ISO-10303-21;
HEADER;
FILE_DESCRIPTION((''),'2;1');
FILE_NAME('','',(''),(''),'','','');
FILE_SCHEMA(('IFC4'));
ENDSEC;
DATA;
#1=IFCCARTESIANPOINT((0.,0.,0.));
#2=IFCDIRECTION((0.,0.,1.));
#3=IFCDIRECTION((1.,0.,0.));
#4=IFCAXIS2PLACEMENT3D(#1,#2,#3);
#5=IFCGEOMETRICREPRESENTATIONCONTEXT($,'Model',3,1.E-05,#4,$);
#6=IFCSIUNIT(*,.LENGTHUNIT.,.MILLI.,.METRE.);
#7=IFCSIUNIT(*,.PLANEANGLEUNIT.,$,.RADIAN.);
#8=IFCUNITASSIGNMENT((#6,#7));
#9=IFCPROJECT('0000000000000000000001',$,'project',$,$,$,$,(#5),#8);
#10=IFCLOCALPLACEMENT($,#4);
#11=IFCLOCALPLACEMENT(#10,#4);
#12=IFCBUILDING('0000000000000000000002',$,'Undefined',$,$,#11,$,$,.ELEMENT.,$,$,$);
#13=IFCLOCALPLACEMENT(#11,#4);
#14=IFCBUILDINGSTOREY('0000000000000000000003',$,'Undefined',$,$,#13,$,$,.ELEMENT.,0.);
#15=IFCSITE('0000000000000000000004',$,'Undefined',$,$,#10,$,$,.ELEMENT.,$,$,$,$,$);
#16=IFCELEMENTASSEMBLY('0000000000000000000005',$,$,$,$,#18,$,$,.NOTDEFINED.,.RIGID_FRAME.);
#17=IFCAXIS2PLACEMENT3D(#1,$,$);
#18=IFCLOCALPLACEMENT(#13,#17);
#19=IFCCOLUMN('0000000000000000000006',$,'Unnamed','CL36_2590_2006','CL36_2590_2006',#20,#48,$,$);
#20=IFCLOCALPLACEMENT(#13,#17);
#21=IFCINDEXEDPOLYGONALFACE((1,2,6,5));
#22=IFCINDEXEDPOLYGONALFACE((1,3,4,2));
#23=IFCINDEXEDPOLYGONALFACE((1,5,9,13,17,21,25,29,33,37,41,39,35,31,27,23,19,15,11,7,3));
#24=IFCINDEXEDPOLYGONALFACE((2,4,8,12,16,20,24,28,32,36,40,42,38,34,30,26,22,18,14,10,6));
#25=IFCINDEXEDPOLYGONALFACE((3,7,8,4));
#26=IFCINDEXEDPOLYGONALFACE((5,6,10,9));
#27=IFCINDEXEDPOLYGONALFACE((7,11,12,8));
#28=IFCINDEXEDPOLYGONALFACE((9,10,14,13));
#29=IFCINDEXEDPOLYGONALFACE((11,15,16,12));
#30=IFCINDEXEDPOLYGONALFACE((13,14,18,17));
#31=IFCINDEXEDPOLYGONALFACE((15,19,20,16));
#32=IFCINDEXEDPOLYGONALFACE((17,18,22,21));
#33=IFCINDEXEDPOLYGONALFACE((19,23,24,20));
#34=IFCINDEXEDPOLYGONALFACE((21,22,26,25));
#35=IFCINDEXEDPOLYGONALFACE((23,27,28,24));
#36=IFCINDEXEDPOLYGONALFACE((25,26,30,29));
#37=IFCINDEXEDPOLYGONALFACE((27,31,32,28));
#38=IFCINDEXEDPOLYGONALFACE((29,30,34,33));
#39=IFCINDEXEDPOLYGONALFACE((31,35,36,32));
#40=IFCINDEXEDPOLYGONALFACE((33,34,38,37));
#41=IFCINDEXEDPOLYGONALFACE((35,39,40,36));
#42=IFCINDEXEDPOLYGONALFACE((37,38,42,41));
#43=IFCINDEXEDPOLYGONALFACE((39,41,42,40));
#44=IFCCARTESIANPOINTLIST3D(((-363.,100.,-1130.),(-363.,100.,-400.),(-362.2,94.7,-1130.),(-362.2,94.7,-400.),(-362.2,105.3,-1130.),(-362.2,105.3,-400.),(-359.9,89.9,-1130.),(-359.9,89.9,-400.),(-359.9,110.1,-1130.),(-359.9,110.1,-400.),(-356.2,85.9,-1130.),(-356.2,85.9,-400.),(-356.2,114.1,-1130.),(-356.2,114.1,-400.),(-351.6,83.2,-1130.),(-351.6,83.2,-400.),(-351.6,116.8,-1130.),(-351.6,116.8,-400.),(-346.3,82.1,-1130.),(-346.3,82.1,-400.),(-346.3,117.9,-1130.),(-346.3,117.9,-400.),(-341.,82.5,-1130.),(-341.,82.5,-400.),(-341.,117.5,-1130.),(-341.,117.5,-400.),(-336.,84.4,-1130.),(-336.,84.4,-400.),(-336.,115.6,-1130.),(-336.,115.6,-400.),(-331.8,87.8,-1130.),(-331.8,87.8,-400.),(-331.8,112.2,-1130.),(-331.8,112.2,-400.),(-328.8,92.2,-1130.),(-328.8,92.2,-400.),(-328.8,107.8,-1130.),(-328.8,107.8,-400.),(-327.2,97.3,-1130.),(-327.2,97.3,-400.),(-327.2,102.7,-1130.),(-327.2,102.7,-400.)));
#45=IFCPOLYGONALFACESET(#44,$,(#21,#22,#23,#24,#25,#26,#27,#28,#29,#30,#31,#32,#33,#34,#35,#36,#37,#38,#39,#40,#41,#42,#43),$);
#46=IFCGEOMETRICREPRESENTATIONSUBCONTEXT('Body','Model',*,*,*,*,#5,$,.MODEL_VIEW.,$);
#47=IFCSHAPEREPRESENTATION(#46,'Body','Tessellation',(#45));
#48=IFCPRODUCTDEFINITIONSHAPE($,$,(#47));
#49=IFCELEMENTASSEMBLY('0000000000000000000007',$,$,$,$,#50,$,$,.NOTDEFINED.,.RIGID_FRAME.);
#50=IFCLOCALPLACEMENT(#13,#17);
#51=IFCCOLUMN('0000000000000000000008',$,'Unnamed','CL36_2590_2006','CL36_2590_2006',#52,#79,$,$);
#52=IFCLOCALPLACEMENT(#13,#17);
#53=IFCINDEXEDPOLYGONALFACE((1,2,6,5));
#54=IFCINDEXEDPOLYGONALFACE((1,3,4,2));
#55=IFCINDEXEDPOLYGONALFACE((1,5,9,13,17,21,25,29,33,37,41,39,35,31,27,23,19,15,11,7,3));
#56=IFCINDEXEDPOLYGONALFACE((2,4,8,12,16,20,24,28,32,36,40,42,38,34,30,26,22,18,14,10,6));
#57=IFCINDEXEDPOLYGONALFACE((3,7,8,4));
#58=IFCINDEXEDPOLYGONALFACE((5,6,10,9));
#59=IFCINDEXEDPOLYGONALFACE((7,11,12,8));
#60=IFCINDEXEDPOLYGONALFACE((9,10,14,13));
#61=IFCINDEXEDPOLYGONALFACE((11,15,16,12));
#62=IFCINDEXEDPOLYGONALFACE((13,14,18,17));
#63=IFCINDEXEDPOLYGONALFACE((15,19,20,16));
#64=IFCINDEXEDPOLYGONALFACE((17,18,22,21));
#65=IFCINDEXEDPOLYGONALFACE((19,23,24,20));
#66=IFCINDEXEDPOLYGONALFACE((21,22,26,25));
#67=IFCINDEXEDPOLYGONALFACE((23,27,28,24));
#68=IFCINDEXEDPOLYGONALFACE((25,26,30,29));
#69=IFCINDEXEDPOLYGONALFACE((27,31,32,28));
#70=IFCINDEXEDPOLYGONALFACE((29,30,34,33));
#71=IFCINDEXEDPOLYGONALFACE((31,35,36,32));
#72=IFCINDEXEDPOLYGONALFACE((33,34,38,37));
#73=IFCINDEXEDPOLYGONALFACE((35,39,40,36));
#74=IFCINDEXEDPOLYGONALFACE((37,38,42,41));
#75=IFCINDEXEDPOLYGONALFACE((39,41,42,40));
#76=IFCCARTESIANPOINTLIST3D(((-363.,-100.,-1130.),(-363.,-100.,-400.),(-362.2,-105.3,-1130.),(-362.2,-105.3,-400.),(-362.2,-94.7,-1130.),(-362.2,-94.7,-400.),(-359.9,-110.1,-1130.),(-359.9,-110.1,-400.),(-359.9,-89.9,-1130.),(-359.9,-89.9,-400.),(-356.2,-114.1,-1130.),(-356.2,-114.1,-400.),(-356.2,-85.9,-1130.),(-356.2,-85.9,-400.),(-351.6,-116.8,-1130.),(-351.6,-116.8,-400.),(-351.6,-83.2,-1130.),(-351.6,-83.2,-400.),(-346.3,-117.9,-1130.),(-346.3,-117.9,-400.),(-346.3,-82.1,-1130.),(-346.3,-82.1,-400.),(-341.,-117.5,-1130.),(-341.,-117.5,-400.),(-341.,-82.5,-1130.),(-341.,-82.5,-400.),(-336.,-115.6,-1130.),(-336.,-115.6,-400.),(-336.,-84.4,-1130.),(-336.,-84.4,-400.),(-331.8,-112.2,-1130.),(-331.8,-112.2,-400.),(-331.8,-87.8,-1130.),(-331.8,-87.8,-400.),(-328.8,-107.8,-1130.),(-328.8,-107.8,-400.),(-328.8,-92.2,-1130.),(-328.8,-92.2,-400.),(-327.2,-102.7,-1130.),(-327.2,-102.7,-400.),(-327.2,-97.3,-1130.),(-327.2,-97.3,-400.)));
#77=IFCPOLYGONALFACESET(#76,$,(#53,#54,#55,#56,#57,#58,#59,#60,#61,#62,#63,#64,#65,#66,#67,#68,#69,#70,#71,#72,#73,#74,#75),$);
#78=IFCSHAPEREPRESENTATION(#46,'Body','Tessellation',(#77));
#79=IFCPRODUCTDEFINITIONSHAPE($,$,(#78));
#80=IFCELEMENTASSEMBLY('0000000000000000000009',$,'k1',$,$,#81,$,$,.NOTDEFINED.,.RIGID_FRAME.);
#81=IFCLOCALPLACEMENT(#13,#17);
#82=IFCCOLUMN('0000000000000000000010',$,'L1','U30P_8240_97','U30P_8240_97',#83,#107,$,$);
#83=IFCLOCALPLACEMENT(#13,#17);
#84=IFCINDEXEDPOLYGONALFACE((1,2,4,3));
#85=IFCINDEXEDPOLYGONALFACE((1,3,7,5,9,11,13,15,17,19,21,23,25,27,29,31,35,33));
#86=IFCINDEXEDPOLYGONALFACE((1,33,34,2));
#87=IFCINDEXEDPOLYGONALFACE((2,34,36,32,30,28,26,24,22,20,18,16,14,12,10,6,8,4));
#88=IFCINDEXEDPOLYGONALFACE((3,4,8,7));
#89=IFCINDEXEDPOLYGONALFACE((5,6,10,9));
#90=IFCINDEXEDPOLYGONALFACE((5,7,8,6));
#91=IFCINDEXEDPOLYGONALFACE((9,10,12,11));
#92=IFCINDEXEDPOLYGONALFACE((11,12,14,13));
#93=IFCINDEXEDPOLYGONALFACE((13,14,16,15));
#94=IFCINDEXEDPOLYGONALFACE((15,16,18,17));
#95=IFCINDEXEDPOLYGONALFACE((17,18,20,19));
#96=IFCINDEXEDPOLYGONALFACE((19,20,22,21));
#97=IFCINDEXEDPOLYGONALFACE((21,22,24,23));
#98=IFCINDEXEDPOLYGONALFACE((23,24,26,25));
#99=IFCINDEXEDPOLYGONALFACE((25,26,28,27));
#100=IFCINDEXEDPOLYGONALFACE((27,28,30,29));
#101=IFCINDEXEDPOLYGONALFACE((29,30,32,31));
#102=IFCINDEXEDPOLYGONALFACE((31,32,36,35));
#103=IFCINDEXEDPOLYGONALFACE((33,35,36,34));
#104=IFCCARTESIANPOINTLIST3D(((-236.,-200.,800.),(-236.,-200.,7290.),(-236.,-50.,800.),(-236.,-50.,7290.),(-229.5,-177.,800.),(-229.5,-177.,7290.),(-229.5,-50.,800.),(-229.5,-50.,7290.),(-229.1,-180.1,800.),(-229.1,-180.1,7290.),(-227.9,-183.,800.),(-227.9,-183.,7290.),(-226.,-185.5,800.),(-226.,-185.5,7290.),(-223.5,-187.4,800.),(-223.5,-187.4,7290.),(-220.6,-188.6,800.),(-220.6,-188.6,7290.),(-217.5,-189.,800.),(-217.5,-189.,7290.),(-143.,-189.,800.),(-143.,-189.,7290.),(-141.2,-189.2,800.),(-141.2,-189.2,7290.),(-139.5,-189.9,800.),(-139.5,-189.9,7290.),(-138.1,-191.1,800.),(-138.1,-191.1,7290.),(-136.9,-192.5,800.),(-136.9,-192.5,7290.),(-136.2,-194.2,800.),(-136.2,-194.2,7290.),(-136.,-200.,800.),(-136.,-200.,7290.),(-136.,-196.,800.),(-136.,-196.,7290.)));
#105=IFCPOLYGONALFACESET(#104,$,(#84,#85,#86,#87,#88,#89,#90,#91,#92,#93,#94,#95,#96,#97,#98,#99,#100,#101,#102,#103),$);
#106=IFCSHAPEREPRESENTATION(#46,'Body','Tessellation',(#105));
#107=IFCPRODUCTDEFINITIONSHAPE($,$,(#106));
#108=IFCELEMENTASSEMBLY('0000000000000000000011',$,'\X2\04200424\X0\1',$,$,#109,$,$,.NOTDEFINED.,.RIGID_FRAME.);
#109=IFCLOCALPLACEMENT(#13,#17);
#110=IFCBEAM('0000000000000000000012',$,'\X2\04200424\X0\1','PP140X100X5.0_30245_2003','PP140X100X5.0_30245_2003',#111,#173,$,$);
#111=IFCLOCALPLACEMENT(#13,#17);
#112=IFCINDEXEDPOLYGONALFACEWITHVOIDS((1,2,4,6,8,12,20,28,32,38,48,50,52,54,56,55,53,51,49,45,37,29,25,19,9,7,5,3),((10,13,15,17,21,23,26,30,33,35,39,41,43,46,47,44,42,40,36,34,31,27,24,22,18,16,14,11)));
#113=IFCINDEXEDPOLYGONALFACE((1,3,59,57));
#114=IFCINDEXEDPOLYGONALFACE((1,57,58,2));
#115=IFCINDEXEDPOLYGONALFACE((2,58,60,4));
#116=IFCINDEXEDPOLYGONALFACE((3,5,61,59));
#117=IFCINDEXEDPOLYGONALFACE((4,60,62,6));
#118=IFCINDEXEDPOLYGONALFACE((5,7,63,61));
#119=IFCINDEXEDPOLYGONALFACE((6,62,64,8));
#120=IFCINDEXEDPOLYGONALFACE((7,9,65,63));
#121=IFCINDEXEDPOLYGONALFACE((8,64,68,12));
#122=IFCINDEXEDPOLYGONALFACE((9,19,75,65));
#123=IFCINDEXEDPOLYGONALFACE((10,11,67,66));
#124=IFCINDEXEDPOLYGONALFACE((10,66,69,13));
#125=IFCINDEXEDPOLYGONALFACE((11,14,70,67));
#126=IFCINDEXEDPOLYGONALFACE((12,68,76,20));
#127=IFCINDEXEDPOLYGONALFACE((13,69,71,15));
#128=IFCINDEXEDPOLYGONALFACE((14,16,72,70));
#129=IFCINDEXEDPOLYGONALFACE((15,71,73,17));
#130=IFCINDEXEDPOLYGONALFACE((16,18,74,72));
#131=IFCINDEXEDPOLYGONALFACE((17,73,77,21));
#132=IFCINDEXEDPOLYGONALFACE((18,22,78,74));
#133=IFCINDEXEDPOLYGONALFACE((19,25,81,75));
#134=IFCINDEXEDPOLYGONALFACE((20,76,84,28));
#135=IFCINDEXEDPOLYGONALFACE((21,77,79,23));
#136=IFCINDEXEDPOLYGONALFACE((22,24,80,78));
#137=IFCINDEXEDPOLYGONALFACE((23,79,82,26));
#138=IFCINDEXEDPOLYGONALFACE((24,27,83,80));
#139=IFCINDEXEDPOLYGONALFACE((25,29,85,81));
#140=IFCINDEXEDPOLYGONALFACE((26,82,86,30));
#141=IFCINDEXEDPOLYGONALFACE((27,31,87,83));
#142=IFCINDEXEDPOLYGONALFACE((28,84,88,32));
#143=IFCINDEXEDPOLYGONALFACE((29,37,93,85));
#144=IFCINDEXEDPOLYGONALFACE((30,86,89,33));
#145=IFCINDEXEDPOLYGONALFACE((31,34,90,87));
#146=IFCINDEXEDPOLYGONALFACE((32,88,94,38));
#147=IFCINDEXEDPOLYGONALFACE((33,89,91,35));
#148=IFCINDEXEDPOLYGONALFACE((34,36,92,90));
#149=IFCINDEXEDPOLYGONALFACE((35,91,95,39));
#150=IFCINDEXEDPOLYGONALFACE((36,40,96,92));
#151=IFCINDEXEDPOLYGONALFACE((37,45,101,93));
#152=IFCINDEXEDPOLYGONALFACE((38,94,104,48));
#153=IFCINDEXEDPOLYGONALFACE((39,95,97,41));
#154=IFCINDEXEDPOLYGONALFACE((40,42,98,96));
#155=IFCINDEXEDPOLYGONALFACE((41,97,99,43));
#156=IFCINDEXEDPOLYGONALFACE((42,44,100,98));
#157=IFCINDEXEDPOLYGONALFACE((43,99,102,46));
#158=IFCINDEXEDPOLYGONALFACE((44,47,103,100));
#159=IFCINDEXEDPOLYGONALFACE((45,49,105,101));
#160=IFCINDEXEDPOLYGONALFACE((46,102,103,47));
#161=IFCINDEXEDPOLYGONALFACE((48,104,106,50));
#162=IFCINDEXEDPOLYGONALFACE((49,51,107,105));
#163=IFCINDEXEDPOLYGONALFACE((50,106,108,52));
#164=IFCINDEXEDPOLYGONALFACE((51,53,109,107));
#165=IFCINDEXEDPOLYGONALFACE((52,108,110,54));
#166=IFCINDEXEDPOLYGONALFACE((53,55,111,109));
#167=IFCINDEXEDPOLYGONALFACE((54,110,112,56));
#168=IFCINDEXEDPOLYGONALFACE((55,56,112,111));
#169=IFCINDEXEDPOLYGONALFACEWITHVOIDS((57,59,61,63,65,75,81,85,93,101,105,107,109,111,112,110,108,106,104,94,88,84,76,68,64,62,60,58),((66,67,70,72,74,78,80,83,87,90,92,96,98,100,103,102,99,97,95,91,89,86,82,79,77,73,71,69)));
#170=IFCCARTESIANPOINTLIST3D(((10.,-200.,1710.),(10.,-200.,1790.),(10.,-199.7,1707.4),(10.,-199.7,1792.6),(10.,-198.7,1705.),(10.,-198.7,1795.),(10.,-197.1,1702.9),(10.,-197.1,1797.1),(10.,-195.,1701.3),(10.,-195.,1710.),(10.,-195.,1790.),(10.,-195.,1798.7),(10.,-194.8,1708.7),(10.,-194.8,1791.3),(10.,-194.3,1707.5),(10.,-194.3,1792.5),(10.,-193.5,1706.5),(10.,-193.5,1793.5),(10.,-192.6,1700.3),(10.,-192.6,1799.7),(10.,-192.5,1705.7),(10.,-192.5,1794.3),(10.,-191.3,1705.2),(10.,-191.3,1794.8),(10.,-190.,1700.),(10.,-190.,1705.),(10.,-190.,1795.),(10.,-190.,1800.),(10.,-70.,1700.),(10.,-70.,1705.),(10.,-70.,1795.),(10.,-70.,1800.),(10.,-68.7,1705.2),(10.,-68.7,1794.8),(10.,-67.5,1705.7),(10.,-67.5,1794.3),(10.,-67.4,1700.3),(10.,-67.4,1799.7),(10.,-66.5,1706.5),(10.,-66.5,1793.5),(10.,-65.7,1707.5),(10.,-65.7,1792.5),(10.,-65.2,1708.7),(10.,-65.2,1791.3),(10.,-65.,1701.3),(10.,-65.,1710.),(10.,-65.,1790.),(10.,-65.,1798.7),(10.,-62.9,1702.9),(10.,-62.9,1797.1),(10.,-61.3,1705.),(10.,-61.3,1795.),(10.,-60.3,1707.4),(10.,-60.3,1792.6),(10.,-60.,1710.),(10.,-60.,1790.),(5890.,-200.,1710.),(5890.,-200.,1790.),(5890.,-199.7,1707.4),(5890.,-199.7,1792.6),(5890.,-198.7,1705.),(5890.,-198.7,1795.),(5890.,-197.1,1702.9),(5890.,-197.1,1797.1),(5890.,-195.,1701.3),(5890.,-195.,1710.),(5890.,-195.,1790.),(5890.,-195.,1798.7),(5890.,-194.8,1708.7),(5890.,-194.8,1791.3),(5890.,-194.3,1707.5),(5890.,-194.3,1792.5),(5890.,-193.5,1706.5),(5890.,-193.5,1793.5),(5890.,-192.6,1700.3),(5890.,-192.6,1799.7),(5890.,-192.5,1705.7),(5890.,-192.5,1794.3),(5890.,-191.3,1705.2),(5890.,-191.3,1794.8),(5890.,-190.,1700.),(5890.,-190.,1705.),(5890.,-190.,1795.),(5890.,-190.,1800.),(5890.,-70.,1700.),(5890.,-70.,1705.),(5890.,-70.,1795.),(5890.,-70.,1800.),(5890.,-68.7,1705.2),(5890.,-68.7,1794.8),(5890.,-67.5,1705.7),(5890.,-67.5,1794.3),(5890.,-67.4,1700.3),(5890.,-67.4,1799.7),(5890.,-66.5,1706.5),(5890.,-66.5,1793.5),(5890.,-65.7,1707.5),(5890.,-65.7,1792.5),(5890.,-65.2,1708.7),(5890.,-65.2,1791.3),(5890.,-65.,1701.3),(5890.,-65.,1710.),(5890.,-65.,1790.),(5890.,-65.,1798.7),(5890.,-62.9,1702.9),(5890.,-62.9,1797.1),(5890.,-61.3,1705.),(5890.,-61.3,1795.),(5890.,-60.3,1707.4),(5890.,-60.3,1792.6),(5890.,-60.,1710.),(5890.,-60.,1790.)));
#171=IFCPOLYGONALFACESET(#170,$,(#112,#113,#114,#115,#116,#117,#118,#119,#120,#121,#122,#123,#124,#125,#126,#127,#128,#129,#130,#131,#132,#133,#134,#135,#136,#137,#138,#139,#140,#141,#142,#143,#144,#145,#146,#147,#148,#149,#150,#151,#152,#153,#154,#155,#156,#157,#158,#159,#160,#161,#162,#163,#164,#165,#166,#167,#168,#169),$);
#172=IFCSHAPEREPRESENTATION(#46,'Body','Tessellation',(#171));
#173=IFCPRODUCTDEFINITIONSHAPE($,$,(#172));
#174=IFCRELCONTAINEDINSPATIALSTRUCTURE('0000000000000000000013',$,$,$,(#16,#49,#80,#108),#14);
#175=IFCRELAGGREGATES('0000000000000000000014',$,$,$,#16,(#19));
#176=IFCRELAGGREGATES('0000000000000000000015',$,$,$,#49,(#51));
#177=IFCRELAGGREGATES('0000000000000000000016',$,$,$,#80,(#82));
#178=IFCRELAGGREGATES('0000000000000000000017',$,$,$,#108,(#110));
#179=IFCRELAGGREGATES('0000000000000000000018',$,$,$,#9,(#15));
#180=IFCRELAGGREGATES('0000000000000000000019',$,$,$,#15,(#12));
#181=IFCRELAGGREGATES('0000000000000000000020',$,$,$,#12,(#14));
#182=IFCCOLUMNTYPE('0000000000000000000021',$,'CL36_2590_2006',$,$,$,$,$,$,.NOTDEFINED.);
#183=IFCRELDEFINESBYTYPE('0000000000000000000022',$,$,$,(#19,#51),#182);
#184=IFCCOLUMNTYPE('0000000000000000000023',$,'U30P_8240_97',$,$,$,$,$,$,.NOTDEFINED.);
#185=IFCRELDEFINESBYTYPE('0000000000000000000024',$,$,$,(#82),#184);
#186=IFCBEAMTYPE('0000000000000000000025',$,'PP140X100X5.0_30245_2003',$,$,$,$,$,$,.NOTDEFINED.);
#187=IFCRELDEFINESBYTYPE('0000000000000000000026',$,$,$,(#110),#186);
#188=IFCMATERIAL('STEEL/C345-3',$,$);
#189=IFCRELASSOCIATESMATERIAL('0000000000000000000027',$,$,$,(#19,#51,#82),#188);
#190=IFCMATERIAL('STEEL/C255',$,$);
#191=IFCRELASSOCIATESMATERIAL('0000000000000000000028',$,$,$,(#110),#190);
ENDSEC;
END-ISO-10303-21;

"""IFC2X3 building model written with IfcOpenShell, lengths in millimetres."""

from ifc_helpers import new_model, si_unit, frame, origin_with_axes, origin_2d_with_axis, place, context, subcontext, project, spatial, hollow_rectangle, circle, u_section, extrude, clip, halfspace, material, type_object, element, aggregate, save


model = new_model("IFC2X3")

# Units and contexts
model_context = context("Model", 3, precision=1e-05, world=origin_with_axes())
body_context = subcontext(model_context, "Body", "Model", "MODEL_VIEW")
ifc_project = project(units=[si_unit("LENGTHUNIT", "METRE", prefix="MILLI"), si_unit("PLANEANGLEUNIT", "RADIAN")], contexts=[model_context])

# Site, building, storey
site_placement = place(None, origin_with_axes())
site = spatial("IfcSite", under=ifc_project, at=site_placement, Name="Undefined", CompositionType="ELEMENT")
building_placement = place(site_placement, origin_with_axes())
building = spatial("IfcBuilding", under=site, at=building_placement, Name="Undefined", CompositionType="ELEMENT")
storey_placement = place(building_placement, origin_with_axes())
storey = spatial("IfcBuildingStorey", under=building, at=storey_placement, Name="Undefined", CompositionType="ELEMENT", Elevation=0.0)

# Element assemblies, columns
ifc_material_1 = material(Name="STEEL/C255")
ifc_material_2 = material(Name="STEEL/C345-3")
column_type_1 = type_object("IfcColumnType", Name="CL36_2590_2006", PredefinedType="NOTDEFINED")
assembly_1_placement = place(storey_placement, origin_with_axes())
assembly_1 = element("IfcElementAssembly", 1, at=assembly_1_placement, inside=storey, AssemblyPlace="NOTDEFINED", PredefinedType="RIGID_FRAME")
column_1_placement = place(assembly_1_placement, frame((-345.0, 100.0, -1130.0), z_axis=(0.0, 0.0, 1.0), x_axis=(0.0, 1.0, 0.0)))
column_1 = element("IfcColumn", 2, at=column_1_placement, type_object=column_type_1, material=ifc_material_2, Name="Unnamed", Description="CL36_2590_2006", ObjectType="CL36_2590_2006", context=body_context, shape_type="SweptSolid", body=[
    extrude(circle(Radius=18.0, at=origin_2d_with_axis()), frame((0.0, 0.0, 730.0), z_axis=(0.0, 0.0, -1.0), x_axis=(0.0, 1.0, 0.0)), (0.0, 0.0, 1.0), 730.0),
])
aggregate(assembly_1, [column_1])
assembly_2_placement = place(storey_placement, origin_with_axes())
assembly_2 = element("IfcElementAssembly", 3, at=assembly_2_placement, inside=storey, AssemblyPlace="NOTDEFINED", PredefinedType="RIGID_FRAME")
column_2_placement = place(assembly_2_placement, frame((-345.0, -100.0, -1130.0), z_axis=(0.0, 0.0, 1.0), x_axis=(0.0, 1.0, 0.0)))
column_2 = element("IfcColumn", 4, at=column_2_placement, type_object=column_type_1, material=ifc_material_2, Name="Unnamed", Description="CL36_2590_2006", ObjectType="CL36_2590_2006", context=body_context, shape_type="SweptSolid", body=[
    extrude(circle(Radius=18.0, at=origin_2d_with_axis()), frame((0.0, 0.0, 730.0), z_axis=(0.0, 0.0, -1.0), x_axis=(0.0, 1.0, 0.0)), (0.0, 0.0, 1.0), 730.0),
])
aggregate(assembly_2, [column_2])
assembly_3_placement = place(storey_placement, origin_with_axes())
assembly_3 = element("IfcElementAssembly", 5, at=assembly_3_placement, inside=storey, Name="k1", AssemblyPlace="NOTDEFINED", PredefinedType="RIGID_FRAME")
column_type_2 = type_object("IfcColumnType", Name="U30P_8240_97", PredefinedType="NOTDEFINED")
column_3_placement = place(assembly_3_placement, frame((-186.0, -50.0, 800.0), z_axis=(0.0, 0.0, 1.0), x_axis=(0.0, -1.0, 0.0)))
column_3 = element("IfcColumn", 6, at=column_3_placement, type_object=column_type_2, material=ifc_material_2, Name="L1", Description="U30P_8240_97", ObjectType="U30P_8240_97", context=body_context, shape_type="Clipping", body=[
    clip(extrude(u_section(Depth=300.0, FlangeWidth=100.0, WebThickness=6.5, FlangeThickness=11.0, FilletRadius=12.0, EdgeRadius=7.0, at=origin_2d_with_axis()), frame((0.0, 0.0, 6490.0), z_axis=(0.0, 0.0, -1.0), x_axis=(0.0, 1.0, 0.0)), (0.0, 0.0, 1.0), 6490.0), halfspace(frame((0.0, -50.0, 0.0), z_axis=(-1.0, 0.0, 0.0), x_axis=(0.0, 1.0, 0.0)), False)),
])
aggregate(assembly_3, [column_3])

# Element assembly, beam
assembly_4_placement = place(storey_placement, origin_with_axes())
assembly_4 = element("IfcElementAssembly", 7, at=assembly_4_placement, inside=storey, Name="РФ1", AssemblyPlace="NOTDEFINED", PredefinedType="RIGID_FRAME")
beam_type_1 = type_object("IfcBeamType", Name="PP140X100X5.0_30245_2003", PredefinedType="NOTDEFINED")
beam_1_placement = place(assembly_4_placement, frame((10.0, -130.0, 1750.0), z_axis=(0.0, -1.0, 0.0), x_axis=(1.0, 0.0, 0.0)))
beam_1 = element("IfcBeam", 8, at=beam_1_placement, type_object=beam_type_1, material=ifc_material_1, Name="РФ1", Description="PP140X100X5.0_30245_2003", ObjectType="PP140X100X5.0_30245_2003", context=body_context, shape_type="SweptSolid", body=[
    extrude(hollow_rectangle(XDim=100.0, YDim=140.0, WallThickness=5.0, InnerFilletRadius=5.0, OuterFilletRadius=10.0, at=origin_2d_with_axis()), frame((5880.0, 0.0, 0.0), z_axis=(-1.0, 0.0, 0.0), x_axis=(0.0, -1.0, 0.0)), (0.0, 0.0, 1.0), 5880.0),
])
aggregate(assembly_4, [beam_1])

save(model, "model.ifc")
